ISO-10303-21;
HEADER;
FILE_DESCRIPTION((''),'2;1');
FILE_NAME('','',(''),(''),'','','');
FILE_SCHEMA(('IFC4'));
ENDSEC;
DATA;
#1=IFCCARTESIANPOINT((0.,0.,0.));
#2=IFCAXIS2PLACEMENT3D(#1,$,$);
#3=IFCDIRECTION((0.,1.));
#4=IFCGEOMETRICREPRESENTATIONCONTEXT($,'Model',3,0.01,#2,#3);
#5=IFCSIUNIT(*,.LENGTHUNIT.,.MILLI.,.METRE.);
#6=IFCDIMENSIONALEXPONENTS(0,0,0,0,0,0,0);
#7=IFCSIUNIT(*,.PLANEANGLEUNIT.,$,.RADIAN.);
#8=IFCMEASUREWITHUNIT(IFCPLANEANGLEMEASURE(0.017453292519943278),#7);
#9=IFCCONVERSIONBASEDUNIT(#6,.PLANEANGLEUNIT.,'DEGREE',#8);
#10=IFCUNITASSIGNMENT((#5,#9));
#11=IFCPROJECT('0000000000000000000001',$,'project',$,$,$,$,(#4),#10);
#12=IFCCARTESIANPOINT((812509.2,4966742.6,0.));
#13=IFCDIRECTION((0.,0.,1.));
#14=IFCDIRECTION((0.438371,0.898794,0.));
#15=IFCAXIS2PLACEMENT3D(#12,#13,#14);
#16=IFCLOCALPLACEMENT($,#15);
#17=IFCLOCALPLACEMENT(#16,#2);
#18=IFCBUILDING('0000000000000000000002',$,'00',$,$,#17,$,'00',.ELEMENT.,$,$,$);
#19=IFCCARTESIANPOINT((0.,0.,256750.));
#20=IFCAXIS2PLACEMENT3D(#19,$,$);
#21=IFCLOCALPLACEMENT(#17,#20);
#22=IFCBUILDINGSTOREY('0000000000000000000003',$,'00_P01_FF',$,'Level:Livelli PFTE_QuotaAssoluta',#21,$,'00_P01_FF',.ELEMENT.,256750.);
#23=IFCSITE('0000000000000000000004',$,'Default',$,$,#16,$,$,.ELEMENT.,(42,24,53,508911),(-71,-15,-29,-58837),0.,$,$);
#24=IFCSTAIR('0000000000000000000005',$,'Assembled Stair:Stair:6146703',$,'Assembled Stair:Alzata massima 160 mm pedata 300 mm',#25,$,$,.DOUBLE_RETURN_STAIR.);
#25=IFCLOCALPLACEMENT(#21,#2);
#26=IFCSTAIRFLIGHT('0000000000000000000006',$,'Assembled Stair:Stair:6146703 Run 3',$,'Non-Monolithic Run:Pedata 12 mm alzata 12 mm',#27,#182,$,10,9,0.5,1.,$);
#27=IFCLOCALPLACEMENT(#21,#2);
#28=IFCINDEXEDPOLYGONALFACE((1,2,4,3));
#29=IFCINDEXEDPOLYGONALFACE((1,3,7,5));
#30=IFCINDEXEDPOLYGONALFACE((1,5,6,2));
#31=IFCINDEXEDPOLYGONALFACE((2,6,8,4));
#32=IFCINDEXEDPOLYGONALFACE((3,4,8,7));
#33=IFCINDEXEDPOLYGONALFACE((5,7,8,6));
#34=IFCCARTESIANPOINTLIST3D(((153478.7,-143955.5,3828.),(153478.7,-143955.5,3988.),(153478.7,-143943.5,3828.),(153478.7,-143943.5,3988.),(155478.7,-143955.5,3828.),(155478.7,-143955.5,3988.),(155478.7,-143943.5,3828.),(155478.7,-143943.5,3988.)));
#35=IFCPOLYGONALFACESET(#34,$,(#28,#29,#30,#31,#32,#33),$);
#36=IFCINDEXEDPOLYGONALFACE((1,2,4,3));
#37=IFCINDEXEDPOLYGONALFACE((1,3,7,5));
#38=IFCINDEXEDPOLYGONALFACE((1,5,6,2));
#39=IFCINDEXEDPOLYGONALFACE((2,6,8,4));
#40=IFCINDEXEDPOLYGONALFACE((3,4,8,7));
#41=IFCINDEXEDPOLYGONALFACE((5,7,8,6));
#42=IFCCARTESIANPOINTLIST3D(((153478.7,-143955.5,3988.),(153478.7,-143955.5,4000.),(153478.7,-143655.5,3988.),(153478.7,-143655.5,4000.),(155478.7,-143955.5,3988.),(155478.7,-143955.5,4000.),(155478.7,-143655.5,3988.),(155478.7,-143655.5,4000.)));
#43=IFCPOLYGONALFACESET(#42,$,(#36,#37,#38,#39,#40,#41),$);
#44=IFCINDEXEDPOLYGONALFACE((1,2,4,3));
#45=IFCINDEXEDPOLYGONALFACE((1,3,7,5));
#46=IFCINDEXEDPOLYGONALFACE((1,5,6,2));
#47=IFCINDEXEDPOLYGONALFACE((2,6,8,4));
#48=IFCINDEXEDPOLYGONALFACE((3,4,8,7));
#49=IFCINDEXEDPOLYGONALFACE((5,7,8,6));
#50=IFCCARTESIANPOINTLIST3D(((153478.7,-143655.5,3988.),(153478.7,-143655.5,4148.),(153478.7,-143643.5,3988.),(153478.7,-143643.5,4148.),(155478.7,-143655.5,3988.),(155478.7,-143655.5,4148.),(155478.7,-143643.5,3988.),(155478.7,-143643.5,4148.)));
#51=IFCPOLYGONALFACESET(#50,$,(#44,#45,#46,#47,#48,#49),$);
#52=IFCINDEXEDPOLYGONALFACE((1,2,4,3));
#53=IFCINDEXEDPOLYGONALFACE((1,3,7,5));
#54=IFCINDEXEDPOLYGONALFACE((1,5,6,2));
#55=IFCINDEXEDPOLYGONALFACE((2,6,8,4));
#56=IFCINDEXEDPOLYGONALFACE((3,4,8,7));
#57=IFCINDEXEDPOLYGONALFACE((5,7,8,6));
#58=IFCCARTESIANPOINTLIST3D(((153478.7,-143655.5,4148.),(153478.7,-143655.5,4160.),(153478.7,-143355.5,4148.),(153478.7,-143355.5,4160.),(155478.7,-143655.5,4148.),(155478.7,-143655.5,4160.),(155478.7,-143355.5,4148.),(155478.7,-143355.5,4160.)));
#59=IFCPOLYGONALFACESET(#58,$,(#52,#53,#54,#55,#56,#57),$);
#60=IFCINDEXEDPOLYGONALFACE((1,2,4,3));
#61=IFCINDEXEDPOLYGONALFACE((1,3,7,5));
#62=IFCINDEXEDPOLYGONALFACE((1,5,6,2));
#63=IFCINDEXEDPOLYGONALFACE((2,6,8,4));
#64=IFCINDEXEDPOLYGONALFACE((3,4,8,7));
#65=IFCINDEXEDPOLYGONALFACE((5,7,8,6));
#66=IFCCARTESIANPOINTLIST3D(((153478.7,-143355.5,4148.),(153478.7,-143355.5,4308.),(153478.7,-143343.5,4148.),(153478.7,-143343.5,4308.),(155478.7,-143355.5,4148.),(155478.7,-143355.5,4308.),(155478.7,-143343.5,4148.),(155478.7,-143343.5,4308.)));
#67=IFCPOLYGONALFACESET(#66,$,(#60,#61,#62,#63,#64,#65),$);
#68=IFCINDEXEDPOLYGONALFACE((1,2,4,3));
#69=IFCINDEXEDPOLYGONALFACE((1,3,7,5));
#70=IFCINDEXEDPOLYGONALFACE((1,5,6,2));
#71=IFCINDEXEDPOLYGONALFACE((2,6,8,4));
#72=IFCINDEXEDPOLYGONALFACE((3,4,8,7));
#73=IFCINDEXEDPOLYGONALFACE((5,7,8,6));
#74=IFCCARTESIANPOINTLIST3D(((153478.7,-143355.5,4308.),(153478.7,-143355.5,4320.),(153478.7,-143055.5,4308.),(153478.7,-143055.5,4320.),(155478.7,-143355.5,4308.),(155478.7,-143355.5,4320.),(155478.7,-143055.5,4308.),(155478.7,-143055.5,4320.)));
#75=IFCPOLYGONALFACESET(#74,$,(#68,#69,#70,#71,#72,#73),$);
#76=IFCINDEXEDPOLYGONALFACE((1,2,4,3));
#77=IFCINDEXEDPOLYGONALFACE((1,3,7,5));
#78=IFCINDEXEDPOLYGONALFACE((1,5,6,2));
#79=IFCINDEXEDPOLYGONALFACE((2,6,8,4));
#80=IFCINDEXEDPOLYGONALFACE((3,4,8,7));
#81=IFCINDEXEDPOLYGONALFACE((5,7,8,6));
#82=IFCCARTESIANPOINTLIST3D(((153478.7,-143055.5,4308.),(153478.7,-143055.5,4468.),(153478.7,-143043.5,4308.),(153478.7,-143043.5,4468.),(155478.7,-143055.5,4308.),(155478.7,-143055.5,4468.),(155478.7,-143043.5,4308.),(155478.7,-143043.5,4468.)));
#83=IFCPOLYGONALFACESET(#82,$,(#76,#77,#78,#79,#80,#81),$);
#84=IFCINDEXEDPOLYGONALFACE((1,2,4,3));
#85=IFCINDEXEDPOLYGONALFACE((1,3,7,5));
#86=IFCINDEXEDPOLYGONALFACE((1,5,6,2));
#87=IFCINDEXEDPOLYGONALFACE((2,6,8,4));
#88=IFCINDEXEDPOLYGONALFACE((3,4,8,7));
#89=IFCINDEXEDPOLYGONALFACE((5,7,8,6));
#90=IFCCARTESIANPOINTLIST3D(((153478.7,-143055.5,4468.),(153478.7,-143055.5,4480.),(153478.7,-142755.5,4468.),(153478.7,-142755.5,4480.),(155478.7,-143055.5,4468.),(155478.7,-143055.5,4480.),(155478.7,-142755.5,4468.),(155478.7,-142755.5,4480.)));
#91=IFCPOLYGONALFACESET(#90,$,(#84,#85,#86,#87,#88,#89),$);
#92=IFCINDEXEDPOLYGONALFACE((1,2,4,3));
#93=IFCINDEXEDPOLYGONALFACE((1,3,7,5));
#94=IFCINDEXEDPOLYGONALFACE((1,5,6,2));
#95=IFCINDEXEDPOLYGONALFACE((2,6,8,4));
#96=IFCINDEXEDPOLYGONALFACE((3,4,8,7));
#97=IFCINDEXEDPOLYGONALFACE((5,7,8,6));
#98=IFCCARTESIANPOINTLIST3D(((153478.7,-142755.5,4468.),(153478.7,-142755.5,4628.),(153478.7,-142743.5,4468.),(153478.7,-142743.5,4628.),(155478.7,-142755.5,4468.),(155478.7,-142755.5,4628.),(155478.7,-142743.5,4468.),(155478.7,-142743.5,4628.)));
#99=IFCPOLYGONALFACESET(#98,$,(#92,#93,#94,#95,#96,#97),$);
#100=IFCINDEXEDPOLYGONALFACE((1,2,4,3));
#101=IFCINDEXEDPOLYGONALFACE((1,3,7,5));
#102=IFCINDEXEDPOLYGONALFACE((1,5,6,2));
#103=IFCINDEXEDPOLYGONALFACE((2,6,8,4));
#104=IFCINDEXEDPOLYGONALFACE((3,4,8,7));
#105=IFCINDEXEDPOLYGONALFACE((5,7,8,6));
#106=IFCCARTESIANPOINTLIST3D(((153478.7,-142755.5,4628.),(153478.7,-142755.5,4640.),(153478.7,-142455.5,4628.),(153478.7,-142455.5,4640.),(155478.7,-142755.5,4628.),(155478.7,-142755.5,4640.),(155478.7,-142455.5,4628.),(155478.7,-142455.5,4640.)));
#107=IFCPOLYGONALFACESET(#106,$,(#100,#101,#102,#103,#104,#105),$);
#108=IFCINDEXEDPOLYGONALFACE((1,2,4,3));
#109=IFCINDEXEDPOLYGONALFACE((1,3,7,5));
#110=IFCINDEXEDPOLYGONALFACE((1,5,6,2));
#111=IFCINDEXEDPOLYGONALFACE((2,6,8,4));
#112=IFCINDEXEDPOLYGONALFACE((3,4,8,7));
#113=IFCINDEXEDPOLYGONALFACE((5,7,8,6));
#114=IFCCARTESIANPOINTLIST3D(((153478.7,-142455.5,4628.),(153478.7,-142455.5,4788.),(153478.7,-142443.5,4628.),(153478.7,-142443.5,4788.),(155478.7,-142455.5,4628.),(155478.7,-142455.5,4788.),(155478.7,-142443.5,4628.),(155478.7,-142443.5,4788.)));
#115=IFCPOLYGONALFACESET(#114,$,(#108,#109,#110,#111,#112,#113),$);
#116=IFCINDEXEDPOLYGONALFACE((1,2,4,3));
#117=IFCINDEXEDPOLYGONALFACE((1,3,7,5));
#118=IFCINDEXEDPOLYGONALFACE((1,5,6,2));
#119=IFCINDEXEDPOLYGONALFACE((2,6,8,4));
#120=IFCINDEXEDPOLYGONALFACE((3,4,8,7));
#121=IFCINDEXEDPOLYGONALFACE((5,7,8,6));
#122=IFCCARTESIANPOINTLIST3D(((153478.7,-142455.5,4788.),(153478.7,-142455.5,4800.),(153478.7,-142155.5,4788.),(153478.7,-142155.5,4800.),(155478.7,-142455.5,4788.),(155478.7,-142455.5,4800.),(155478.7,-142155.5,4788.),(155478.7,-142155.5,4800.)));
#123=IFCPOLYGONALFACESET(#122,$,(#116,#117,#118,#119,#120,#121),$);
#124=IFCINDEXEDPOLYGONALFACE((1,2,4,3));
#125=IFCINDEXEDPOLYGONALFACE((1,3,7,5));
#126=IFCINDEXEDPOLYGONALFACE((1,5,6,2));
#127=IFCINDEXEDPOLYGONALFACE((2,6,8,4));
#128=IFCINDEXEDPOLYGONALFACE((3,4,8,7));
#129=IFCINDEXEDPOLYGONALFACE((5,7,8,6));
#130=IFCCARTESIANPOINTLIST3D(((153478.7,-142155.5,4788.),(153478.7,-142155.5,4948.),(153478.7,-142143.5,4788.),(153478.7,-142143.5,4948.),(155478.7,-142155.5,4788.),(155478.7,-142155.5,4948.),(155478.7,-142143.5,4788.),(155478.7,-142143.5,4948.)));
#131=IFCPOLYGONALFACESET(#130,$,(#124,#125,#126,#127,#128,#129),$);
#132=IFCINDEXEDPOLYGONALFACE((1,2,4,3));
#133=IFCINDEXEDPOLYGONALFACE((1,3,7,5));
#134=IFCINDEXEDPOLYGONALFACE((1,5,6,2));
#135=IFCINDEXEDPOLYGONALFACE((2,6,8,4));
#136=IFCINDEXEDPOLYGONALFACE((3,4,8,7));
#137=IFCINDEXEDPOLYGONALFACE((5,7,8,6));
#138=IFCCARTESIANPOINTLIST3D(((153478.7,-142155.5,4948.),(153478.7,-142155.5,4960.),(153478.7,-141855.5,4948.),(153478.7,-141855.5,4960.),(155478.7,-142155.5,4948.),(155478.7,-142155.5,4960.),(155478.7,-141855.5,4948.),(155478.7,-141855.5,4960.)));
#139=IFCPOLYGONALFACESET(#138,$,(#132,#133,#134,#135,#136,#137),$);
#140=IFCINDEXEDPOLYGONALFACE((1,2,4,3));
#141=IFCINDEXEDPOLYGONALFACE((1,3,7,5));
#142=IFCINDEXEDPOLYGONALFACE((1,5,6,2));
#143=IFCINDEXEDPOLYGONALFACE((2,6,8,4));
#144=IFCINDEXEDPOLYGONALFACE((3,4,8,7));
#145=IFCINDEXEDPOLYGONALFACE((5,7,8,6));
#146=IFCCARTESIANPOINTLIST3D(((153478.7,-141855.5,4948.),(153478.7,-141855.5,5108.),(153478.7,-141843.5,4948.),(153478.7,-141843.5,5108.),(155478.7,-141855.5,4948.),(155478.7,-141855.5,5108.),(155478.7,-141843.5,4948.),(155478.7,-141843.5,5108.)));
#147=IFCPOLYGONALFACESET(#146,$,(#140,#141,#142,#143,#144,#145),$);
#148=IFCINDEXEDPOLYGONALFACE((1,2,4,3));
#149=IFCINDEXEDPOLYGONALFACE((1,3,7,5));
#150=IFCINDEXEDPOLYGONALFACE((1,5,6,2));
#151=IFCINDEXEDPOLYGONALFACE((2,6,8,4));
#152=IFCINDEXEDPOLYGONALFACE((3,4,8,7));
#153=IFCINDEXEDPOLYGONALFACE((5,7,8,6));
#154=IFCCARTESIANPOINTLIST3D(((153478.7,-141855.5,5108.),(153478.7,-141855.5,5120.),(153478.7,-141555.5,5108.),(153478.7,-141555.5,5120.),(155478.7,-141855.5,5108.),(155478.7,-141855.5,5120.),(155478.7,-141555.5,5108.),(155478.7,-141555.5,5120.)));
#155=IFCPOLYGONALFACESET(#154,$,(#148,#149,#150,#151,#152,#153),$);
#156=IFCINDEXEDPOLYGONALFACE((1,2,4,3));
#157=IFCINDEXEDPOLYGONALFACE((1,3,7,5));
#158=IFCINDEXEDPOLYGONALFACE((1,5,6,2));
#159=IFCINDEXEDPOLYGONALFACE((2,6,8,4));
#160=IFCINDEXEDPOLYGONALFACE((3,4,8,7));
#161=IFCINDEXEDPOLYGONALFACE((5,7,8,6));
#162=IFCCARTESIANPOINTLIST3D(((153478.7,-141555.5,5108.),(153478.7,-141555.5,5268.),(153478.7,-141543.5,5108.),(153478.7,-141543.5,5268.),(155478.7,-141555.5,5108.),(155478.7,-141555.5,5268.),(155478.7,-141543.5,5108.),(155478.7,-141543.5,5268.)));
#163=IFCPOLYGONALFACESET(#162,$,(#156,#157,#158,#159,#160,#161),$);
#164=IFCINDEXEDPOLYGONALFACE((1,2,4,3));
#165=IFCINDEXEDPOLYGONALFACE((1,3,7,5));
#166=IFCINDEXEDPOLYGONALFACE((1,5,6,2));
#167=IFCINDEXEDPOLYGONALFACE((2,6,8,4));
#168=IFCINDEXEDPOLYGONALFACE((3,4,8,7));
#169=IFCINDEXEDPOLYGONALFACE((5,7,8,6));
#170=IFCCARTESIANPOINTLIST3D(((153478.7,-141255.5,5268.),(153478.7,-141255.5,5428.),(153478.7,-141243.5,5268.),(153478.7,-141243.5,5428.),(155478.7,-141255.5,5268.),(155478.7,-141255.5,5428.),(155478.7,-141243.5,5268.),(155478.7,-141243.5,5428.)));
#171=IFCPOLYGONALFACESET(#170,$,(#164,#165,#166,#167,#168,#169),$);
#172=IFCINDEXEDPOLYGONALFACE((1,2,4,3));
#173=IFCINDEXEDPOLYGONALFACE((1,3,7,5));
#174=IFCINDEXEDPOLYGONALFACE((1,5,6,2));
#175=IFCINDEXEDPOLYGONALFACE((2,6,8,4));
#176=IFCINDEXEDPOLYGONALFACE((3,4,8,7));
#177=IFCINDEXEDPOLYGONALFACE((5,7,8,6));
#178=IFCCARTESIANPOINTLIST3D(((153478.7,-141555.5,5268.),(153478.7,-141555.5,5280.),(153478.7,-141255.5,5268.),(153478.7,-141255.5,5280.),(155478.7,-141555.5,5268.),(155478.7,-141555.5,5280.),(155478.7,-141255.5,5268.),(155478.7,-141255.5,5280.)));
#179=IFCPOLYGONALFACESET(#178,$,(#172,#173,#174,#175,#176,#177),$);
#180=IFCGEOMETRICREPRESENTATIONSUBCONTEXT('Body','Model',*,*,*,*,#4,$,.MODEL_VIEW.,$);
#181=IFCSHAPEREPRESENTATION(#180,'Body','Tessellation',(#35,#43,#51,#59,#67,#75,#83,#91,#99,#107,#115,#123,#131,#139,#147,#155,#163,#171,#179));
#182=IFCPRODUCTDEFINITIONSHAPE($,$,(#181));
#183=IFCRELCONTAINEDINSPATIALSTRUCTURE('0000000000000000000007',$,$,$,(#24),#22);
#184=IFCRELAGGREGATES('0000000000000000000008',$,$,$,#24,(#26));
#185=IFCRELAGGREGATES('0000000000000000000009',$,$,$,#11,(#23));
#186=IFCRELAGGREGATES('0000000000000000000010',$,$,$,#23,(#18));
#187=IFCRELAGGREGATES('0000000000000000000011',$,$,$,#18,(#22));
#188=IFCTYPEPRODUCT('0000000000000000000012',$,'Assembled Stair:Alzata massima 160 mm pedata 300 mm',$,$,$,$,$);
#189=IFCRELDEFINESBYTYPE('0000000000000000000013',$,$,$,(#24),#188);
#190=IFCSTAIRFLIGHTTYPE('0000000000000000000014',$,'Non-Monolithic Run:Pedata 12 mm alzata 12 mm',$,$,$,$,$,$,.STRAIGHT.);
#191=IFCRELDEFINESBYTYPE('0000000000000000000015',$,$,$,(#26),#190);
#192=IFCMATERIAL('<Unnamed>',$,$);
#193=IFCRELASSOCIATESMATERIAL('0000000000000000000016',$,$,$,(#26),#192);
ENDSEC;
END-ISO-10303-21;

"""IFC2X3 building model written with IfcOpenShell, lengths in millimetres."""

from ifc_helpers import new_model, entity, si_unit, converted_unit, direction, frame, frame_2d, origin, place, context, subcontext, project, spatial, rectangle, extrude, material, type_object, element, aggregate, save


model = new_model("IFC2X3")

# Units and contexts
model_context = context("Model", 3, precision=0.01, world=origin(), true_north=direction((0.0, 1.0)))
body_context = subcontext(model_context, "Body", "Model", "MODEL_VIEW")
ifc_project = project(units=[si_unit("LENGTHUNIT", "METRE", prefix="MILLI"), converted_unit("PLANEANGLEUNIT", "DEGREE", entity("IfcPlaneAngleMeasure", 0.017453292519943278), si_unit("PLANEANGLEUNIT", "RADIAN"), dimensions=[0, 0, 0, 0, 0, 0, 0])], contexts=[model_context])

# Site, building, storey
site_placement = place(None, frame((812509.2, 4966742.6, 0.0), z_axis=(0.0, 0.0, 1.0), x_axis=(0.438371, 0.898794, 0.0)))
site = spatial("IfcSite", under=ifc_project, at=site_placement, Name="Default", CompositionType="ELEMENT", RefLatitude=(42, 24, 53, 508911), RefLongitude=(-71, -15, -29, -58837), RefElevation=0.0)
building_placement = place(site_placement, origin())
building = spatial("IfcBuilding", under=site, at=building_placement, Name="00", LongName="00", CompositionType="ELEMENT")
storey_placement = place(building_placement, frame((0.0, 0.0, 256750.0)))
storey = spatial("IfcBuildingStorey", under=building, at=storey_placement, Name="00_P01_FF", ObjectType="Level:Livelli PFTE_QuotaAssoluta", LongName="00_P01_FF", CompositionType="ELEMENT", Elevation=256750.0)

# Stair
type_product = type_object("IfcTypeProduct", Name="Assembled Stair:Alzata massima 160 mm pedata 300 mm")
stair_1_placement = place(storey_placement, origin())
stair_1 = element("IfcStair", 1, at=stair_1_placement, inside=storey, type_object=type_product, Name="Assembled Stair:Stair:6146703", ObjectType="Assembled Stair:Alzata massima 160 mm pedata 300 mm", ShapeType="DOUBLE_RETURN_STAIR")
ifc_material = material(Name="<Unnamed>")

# Stair flight
stair_flight_type = type_object("IfcStairFlightType", Name="Non-Monolithic Run:Pedata 12 mm alzata 12 mm", PredefinedType="STRAIGHT")
stair_flight_1_placement = place(stair_1_placement, origin())
stair_flight_1 = element("IfcStairFlight", 2, at=stair_flight_1_placement, type_object=stair_flight_type, material=ifc_material, Name="Assembled Stair:Stair:6146703 Run 3", ObjectType="Non-Monolithic Run:Pedata 12 mm alzata 12 mm", NumberOfRiser=10, NumberOfTreads=9, RiserHeight=0.5, TreadLength=1.0, context=body_context, shape_type="SweptSolid", body=[
    extrude(rectangle(XDim=2000.0, YDim=12.0, at=frame_2d((0.0, 0.0), x_axis=(1.0, 0.0))), frame((154478.7, -143949.5, 3828.0), z_axis=(0.0, 0.0, 1.0), x_axis=(-1.0, 0.0, 0.0)), (0.0, 0.0, 1.0), 160.0),
    extrude(rectangle(XDim=300.0, YDim=2000.0, at=frame_2d((0.0, 0.0), x_axis=(1.0, 0.0))), frame((154478.7, -143805.5, 3988.0), z_axis=(0.0, 0.0, 1.0), x_axis=(0.0, -1.0, 0.0)), (0.0, 0.0, 1.0), 12.0),
    extrude(rectangle(XDim=2000.0, YDim=12.0, at=frame_2d((0.0, 0.0), x_axis=(1.0, 0.0))), frame((154478.7, -143649.5, 3988.0), z_axis=(0.0, 0.0, 1.0), x_axis=(-1.0, 0.0, 0.0)), (0.0, 0.0, 1.0), 160.0),
    extrude(rectangle(XDim=300.0, YDim=2000.0, at=frame_2d((0.0, 0.0), x_axis=(1.0, 0.0))), frame((154478.7, -143505.5, 4148.0), z_axis=(0.0, 0.0, 1.0), x_axis=(0.0, -1.0, 0.0)), (0.0, 0.0, 1.0), 12.0),
    extrude(rectangle(XDim=2000.0, YDim=12.0, at=frame_2d((0.0, 0.0), x_axis=(1.0, 0.0))), frame((154478.7, -143349.5, 4148.0), z_axis=(0.0, 0.0, 1.0), x_axis=(-1.0, 0.0, 0.0)), (0.0, 0.0, 1.0), 160.0),
    extrude(rectangle(XDim=300.0, YDim=2000.0, at=frame_2d((0.0, 0.0), x_axis=(1.0, 0.0))), frame((154478.7, -143205.5, 4308.0), z_axis=(0.0, 0.0, 1.0), x_axis=(0.0, -1.0, 0.0)), (0.0, 0.0, 1.0), 12.0),
    extrude(rectangle(XDim=2000.0, YDim=12.0, at=frame_2d((0.0, 0.0), x_axis=(1.0, 0.0))), frame((154478.7, -143049.5, 4308.0), z_axis=(0.0, 0.0, 1.0), x_axis=(-1.0, 0.0, 0.0)), (0.0, 0.0, 1.0), 160.0),
    extrude(rectangle(XDim=300.0, YDim=2000.0, at=frame_2d((0.0, 0.0), x_axis=(1.0, 0.0))), frame((154478.7, -142905.5, 4468.0), z_axis=(0.0, 0.0, 1.0), x_axis=(0.0, -1.0, 0.0)), (0.0, 0.0, 1.0), 12.0),
    extrude(rectangle(XDim=2000.0, YDim=12.0, at=frame_2d((0.0, 0.0), x_axis=(1.0, 0.0))), frame((154478.7, -142749.5, 4468.0), z_axis=(0.0, 0.0, 1.0), x_axis=(-1.0, 0.0, 0.0)), (0.0, 0.0, 1.0), 160.0),
    extrude(rectangle(XDim=300.0, YDim=2000.0, at=frame_2d((0.0, 0.0), x_axis=(1.0, 0.0))), frame((154478.7, -142605.5, 4628.0), z_axis=(0.0, 0.0, 1.0), x_axis=(0.0, -1.0, 0.0)), (0.0, 0.0, 1.0), 12.0),
    extrude(rectangle(XDim=2000.0, YDim=12.0, at=frame_2d((0.0, 0.0), x_axis=(1.0, 0.0))), frame((154478.7, -142449.5, 4628.0), z_axis=(0.0, 0.0, 1.0), x_axis=(-1.0, 0.0, 0.0)), (0.0, 0.0, 1.0), 160.0),
    extrude(rectangle(XDim=300.0, YDim=2000.0, at=frame_2d((0.0, 0.0), x_axis=(1.0, 0.0))), frame((154478.7, -142305.5, 4788.0), z_axis=(0.0, 0.0, 1.0), x_axis=(0.0, -1.0, 0.0)), (0.0, 0.0, 1.0), 12.0),
    extrude(rectangle(XDim=2000.0, YDim=12.0, at=frame_2d((0.0, 0.0), x_axis=(1.0, 0.0))), frame((154478.7, -142149.5, 4788.0), z_axis=(0.0, 0.0, 1.0), x_axis=(-1.0, 0.0, 0.0)), (0.0, 0.0, 1.0), 160.0),
    extrude(rectangle(XDim=300.0, YDim=2000.0, at=frame_2d((0.0, 0.0), x_axis=(1.0, 0.0))), frame((154478.7, -142005.5, 4948.0), z_axis=(0.0, 0.0, 1.0), x_axis=(0.0, -1.0, 0.0)), (0.0, 0.0, 1.0), 12.0),
    extrude(rectangle(XDim=2000.0, YDim=12.0, at=frame_2d((0.0, 0.0), x_axis=(1.0, 0.0))), frame((154478.7, -141849.5, 4948.0), z_axis=(0.0, 0.0, 1.0), x_axis=(-1.0, 0.0, 0.0)), (0.0, 0.0, 1.0), 160.0),
    extrude(rectangle(XDim=300.0, YDim=2000.0, at=frame_2d((0.0, 0.0), x_axis=(1.0, 0.0))), frame((154478.7, -141705.5, 5108.0), z_axis=(0.0, 0.0, 1.0), x_axis=(0.0, -1.0, 0.0)), (0.0, 0.0, 1.0), 12.0),
    extrude(rectangle(XDim=2000.0, YDim=12.0, at=frame_2d((0.0, 0.0), x_axis=(1.0, 0.0))), frame((154478.7, -141549.5, 5108.0), z_axis=(0.0, 0.0, 1.0), x_axis=(-1.0, 0.0, 0.0)), (0.0, 0.0, 1.0), 160.0),
    extrude(rectangle(XDim=2000.0, YDim=12.0, at=frame_2d((0.0, 0.0), x_axis=(1.0, 0.0))), frame((154478.7, -141249.5, 5268.0), z_axis=(0.0, 0.0, 1.0), x_axis=(-1.0, 0.0, 0.0)), (0.0, 0.0, 1.0), 160.0),
    extrude(rectangle(XDim=300.0, YDim=2000.0, at=frame_2d((0.0, 0.0), x_axis=(1.0, 0.0))), frame((154478.7, -141405.5, 5268.0), z_axis=(0.0, 0.0, 1.0), x_axis=(0.0, -1.0, 0.0)), (0.0, 0.0, 1.0), 12.0),
])
aggregate(stair_1, [stair_flight_1])

save(model, "model.ifc")
